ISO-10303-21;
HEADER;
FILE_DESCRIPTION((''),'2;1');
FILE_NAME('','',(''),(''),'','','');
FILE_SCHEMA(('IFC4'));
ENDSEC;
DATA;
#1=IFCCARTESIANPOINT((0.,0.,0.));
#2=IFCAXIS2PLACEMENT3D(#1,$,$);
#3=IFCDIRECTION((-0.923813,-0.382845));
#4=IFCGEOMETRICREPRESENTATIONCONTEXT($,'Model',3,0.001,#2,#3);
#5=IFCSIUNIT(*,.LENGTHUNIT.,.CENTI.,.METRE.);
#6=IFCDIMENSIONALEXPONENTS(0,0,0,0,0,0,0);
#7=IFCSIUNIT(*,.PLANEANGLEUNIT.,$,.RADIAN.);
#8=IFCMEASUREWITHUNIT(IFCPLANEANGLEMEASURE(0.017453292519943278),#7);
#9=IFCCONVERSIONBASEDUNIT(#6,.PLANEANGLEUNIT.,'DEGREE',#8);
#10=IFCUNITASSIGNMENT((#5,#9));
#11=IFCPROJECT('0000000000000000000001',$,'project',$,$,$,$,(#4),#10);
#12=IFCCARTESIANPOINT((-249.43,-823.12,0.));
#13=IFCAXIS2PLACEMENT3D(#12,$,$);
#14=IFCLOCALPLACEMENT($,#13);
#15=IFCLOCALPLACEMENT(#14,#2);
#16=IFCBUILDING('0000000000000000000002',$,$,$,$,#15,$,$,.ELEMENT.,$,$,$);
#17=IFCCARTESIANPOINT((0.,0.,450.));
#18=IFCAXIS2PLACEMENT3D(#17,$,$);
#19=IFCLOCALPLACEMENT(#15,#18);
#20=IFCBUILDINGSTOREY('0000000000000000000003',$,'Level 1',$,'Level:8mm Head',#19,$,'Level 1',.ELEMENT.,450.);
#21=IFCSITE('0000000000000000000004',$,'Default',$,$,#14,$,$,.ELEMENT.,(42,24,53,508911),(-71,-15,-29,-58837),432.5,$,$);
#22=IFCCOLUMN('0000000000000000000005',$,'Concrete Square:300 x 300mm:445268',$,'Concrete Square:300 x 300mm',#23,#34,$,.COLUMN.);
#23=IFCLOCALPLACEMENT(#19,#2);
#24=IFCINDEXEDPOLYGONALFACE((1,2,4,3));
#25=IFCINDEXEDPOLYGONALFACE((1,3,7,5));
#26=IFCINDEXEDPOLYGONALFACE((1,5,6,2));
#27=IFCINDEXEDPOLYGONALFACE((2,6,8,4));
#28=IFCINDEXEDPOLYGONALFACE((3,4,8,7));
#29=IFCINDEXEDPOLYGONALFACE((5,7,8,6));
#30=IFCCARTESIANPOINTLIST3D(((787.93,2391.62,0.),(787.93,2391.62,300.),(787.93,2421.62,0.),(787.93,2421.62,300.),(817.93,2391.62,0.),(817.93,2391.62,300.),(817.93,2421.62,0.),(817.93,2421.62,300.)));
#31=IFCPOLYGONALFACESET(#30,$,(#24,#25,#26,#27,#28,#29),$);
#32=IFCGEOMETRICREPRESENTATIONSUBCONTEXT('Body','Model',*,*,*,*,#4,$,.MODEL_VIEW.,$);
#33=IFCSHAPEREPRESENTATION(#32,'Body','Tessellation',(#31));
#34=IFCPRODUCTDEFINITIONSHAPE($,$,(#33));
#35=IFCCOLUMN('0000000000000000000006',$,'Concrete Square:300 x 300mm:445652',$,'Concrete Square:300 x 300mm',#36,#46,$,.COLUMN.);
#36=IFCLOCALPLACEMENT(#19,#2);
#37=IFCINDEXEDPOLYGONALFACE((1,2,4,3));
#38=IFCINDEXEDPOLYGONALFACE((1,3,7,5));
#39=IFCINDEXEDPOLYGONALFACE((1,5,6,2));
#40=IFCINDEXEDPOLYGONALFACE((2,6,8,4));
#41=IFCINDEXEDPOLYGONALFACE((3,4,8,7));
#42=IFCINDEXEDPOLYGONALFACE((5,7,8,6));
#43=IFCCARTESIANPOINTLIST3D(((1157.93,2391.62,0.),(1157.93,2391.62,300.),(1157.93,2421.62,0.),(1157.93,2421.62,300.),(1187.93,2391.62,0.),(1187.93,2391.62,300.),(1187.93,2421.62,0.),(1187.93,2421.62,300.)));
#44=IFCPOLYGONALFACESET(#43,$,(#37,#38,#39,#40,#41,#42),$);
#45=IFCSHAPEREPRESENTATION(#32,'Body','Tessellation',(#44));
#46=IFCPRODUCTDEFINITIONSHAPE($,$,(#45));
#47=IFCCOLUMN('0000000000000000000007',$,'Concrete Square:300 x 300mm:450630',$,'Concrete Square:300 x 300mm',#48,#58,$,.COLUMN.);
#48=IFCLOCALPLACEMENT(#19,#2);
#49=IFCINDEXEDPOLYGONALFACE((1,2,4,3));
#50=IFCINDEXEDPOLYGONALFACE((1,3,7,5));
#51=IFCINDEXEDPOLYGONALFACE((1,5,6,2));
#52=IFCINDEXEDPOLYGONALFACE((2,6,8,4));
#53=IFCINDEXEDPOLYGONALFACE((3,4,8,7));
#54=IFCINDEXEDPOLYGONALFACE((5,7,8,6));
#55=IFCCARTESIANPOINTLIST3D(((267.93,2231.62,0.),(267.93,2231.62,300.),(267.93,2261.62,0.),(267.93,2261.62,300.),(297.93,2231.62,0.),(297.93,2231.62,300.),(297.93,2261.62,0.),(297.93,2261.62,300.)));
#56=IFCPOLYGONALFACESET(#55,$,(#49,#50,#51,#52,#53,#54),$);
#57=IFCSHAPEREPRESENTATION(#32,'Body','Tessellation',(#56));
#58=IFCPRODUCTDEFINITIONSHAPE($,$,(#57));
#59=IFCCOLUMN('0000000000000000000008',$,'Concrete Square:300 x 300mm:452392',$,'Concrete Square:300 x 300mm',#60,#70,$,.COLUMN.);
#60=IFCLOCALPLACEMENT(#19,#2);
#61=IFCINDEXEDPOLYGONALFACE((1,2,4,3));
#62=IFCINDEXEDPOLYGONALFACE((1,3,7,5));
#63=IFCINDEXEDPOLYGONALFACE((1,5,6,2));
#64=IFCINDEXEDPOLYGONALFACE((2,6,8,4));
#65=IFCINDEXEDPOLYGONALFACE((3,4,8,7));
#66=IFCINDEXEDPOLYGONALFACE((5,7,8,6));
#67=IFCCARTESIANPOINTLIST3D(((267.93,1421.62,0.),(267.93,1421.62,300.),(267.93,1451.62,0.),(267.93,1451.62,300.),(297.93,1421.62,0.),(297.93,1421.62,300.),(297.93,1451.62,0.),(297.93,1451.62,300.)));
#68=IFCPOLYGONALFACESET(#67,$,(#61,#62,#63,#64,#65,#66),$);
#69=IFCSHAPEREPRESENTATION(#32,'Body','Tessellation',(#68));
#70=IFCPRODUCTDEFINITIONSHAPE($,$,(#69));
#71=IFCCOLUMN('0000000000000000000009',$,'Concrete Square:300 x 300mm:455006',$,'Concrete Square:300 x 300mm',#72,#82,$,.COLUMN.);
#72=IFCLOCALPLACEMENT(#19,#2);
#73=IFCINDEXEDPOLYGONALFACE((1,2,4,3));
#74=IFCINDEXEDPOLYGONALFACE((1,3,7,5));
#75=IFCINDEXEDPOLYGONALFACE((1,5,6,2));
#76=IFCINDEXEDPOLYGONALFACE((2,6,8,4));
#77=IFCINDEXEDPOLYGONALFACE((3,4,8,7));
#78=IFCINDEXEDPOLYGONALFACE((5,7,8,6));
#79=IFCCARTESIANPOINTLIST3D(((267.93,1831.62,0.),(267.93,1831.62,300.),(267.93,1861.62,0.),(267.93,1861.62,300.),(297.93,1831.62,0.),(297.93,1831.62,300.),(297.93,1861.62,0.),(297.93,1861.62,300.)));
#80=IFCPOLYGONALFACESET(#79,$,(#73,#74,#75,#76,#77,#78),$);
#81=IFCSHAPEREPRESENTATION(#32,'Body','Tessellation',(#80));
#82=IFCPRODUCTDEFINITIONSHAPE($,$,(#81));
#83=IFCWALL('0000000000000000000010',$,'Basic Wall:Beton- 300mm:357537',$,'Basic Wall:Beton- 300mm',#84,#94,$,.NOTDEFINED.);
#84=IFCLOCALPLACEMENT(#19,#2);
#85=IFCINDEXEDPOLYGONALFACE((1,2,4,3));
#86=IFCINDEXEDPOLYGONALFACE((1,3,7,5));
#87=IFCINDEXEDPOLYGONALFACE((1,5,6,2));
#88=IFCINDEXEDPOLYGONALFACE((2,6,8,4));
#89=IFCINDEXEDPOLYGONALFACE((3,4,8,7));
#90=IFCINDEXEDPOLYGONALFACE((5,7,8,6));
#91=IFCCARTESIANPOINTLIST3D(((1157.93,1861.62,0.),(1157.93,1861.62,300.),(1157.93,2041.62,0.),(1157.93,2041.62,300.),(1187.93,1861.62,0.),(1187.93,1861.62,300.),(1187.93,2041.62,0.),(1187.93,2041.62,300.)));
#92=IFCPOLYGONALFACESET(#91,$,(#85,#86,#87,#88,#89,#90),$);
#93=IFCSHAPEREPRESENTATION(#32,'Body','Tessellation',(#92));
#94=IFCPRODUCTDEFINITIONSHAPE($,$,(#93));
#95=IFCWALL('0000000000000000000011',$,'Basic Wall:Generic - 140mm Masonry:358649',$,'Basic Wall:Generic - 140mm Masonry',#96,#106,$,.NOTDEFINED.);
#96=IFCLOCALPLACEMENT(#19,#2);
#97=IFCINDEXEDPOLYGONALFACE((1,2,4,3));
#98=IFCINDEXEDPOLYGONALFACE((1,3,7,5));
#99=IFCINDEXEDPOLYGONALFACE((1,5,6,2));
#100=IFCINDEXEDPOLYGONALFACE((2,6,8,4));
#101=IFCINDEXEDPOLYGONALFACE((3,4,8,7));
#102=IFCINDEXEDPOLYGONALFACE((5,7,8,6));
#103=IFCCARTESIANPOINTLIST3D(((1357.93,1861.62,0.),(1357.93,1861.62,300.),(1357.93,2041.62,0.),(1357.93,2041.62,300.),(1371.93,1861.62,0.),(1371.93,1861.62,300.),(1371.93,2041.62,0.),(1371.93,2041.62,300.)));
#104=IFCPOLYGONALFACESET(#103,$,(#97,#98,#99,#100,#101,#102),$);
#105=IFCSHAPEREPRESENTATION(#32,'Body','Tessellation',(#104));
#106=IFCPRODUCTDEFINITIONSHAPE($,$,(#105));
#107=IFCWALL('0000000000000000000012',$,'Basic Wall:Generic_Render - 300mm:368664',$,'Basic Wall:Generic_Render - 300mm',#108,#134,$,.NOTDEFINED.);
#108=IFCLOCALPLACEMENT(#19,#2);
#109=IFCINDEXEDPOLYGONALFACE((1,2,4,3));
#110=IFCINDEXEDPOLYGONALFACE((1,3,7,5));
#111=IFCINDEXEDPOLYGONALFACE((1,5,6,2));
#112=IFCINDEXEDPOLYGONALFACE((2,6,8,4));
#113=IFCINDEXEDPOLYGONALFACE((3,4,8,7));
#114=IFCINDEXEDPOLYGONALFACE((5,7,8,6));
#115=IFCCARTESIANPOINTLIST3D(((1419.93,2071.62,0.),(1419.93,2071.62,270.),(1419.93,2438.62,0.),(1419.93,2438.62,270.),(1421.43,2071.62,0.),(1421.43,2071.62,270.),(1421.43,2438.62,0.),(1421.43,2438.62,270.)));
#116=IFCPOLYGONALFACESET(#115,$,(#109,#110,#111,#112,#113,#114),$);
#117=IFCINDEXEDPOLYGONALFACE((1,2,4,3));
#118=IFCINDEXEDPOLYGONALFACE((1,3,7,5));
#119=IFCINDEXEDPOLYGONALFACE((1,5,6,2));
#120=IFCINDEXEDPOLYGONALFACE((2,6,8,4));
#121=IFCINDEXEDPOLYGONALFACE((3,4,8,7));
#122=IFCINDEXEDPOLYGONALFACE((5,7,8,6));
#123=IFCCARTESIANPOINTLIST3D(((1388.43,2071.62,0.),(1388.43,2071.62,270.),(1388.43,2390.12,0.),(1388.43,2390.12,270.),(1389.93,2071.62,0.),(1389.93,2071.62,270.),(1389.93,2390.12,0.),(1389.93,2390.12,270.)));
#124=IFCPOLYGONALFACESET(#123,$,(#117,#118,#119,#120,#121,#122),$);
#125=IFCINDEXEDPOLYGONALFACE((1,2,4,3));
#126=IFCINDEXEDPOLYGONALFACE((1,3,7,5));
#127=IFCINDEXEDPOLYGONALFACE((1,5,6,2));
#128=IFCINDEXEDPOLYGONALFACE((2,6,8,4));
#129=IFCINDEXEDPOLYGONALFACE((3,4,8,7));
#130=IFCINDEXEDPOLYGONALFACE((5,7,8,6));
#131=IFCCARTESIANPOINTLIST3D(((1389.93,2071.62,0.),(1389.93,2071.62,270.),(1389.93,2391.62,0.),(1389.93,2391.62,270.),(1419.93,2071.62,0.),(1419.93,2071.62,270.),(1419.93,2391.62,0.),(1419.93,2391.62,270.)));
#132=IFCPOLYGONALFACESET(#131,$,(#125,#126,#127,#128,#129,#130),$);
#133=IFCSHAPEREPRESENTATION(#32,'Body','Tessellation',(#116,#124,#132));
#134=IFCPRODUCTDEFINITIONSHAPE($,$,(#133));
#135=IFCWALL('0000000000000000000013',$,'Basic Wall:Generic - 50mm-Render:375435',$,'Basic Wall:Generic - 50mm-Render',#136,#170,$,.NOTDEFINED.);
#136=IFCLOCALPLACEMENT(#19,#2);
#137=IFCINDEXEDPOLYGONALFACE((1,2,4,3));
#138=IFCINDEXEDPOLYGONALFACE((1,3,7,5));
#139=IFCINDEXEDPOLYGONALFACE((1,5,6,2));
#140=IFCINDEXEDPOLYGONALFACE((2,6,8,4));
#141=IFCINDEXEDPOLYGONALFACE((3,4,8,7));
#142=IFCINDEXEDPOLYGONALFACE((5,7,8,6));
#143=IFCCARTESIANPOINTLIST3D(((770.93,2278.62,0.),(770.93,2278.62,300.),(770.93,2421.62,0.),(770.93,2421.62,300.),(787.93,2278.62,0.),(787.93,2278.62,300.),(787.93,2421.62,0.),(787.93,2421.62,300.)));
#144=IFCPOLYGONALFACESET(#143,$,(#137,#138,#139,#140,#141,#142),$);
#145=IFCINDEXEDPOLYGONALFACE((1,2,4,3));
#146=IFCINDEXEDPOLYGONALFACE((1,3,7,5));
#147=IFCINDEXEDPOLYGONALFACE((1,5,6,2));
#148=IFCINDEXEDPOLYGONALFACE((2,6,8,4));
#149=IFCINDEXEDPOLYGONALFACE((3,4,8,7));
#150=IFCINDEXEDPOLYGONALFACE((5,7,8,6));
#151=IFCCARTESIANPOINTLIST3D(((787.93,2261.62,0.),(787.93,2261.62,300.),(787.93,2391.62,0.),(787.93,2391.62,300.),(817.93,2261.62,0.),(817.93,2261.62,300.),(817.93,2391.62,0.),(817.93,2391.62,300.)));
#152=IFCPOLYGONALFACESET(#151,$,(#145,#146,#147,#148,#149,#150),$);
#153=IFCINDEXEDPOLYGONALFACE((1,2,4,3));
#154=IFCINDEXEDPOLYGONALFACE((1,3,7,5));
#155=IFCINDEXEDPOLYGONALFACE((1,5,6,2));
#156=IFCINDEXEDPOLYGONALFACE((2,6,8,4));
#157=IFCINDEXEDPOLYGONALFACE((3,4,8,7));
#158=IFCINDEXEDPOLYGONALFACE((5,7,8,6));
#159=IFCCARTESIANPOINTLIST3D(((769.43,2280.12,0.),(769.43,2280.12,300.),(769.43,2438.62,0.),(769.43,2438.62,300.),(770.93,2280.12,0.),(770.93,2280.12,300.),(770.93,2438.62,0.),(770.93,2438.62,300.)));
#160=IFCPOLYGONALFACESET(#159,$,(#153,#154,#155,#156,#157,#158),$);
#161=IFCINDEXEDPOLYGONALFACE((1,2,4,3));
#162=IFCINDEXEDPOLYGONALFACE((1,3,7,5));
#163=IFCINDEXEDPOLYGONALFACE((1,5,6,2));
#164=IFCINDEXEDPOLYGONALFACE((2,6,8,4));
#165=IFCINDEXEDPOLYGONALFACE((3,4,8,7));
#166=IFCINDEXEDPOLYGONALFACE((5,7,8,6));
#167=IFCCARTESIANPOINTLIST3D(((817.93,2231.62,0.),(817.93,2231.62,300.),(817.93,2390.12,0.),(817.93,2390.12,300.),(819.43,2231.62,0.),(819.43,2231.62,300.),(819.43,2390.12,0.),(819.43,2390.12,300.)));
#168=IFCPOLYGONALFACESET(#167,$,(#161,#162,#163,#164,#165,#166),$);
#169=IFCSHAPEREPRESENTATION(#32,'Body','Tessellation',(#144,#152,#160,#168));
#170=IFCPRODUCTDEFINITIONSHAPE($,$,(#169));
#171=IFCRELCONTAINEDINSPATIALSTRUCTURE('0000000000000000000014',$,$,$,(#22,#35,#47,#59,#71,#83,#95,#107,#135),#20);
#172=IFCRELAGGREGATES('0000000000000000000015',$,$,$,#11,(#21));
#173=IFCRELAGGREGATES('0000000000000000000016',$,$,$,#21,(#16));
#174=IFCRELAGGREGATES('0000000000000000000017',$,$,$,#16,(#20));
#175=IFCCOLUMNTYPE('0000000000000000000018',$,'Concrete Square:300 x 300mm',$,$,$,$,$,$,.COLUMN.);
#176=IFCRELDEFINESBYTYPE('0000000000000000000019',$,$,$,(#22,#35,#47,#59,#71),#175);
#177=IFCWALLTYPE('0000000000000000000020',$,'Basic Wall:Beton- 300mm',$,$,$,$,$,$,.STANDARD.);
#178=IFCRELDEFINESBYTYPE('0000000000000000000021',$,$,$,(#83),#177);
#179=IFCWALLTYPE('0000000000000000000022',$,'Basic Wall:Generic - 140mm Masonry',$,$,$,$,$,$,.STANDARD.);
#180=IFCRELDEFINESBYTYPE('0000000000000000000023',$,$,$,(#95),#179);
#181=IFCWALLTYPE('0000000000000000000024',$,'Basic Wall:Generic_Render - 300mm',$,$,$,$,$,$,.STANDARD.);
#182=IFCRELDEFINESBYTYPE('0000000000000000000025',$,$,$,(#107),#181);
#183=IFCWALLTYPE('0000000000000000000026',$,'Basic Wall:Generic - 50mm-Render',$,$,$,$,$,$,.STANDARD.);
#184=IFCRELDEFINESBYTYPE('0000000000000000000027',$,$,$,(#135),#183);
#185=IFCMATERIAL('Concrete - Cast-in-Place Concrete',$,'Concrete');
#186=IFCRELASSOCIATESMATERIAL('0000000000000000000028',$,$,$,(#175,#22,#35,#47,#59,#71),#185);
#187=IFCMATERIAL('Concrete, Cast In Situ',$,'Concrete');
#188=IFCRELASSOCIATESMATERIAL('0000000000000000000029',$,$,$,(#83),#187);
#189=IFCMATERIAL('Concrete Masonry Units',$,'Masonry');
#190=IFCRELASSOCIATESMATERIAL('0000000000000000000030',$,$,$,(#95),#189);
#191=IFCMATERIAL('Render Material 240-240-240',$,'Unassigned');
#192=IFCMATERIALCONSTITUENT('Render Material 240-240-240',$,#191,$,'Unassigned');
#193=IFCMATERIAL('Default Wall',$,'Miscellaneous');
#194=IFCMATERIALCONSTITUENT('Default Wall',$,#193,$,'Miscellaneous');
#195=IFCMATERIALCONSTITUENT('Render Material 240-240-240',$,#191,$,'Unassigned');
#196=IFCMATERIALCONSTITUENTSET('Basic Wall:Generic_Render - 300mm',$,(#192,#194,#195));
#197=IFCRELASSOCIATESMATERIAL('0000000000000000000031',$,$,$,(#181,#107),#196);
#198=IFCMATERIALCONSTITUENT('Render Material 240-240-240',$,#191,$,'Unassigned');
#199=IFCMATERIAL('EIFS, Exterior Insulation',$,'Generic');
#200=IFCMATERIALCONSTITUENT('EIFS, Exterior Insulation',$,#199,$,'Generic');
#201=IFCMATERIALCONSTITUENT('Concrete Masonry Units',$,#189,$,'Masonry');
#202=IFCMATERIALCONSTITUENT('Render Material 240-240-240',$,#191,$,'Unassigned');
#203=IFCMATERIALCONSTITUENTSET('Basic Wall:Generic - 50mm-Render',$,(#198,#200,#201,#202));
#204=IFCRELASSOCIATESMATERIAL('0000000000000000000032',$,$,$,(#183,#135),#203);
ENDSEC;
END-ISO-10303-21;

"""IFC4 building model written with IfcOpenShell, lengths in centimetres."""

from ifc_helpers import new_model, entity, si_unit, converted_unit, direction, frame, origin, place, context, subcontext, project, spatial, indexed_curve, outline, extrude, source, transform, mapped, material, constituent, constituent_set, type_object, type_shapes, element, save


model = new_model("IFC4")

# Units and contexts
model_context = context("Model", 3, precision=0.001, world=origin(), true_north=direction((-0.923813, -0.382845)))
body_context = subcontext(model_context, "Body", "Model", "MODEL_VIEW")
ifc_project = project(units=[si_unit("LENGTHUNIT", "METRE", prefix="CENTI"), converted_unit("PLANEANGLEUNIT", "DEGREE", entity("IfcPlaneAngleMeasure", 0.017453292519943278), si_unit("PLANEANGLEUNIT", "RADIAN"), dimensions=[0, 0, 0, 0, 0, 0, 0])], contexts=[model_context])

# Site, building, storey
site_placement = place(None, frame((-249.43, -823.12, 0.0)))
site = spatial("IfcSite", under=ifc_project, at=site_placement, Name="Default", CompositionType="ELEMENT", RefLatitude=(42, 24, 53, 508911), RefLongitude=(-71, -15, -29, -58837), RefElevation=432.5)
building_placement = place(site_placement, origin())
building = spatial("IfcBuilding", under=site, at=building_placement, CompositionType="ELEMENT")
storey_placement = place(building_placement, frame((0.0, 0.0, 450.0)))
storey = spatial("IfcBuildingStorey", under=building, at=storey_placement, Name="Level 1", ObjectType="Level:8mm Head", LongName="Level 1", CompositionType="ELEMENT", Elevation=450.0)

# Columns
ifc_material_1 = material(Name="Concrete - Cast-in-Place Concrete", Category="Concrete")
column_type = type_object("IfcColumnType", Name="Concrete Square:300 x 300mm", PredefinedType="COLUMN", material=ifc_material_1)
shared_shape_1 = source(origin(), body_context, "Body", "SweptSolid", [
    extrude(outline(indexed_curve([(-15.0, -15.0), (15.0, -15.0), (15.0, 15.0), (-15.0, 15.0), (-15.0, -15.0)], self_intersect=False)), frame((0.0, 0.0, 450.0), z_axis=(0.0, 0.0, 1.0), x_axis=(-1.0, 0.0, 0.0)), (0.0, 0.0, 1.0), 300.0),
])
type_shapes(column_type, [shared_shape_1])
for number, where, name in (
    (1, (802.93, 2406.62, -450.0), "Concrete Square:300 x 300mm:445268"),
    (2, (1172.93, 2406.62, -450.0), "Concrete Square:300 x 300mm:445652"),
    (3, (282.93, 2246.62, -450.0), "Concrete Square:300 x 300mm:450630"),
    (4, (282.93, 1436.62, -450.0), "Concrete Square:300 x 300mm:452392"),
    (5, (282.93, 1846.62, -450.0), "Concrete Square:300 x 300mm:455006"),
):
    element("IfcColumn", number, at=place(storey_placement, frame(where)), inside=storey, type_object=column_type, material=ifc_material_1, Name=name, ObjectType="Concrete Square:300 x 300mm", PredefinedType="COLUMN", context=body_context, shape_type="MappedRepresentation", body=[
        mapped(shared_shape_1, transform((0.0, 0.0, 0.0), scale=1.0)),
    ])

# Walls
ifc_material_2 = material(Name="Concrete, Cast In Situ", Category="Concrete")
wall_type_1 = type_object("IfcWallType", Name="Basic Wall:Beton- 300mm", PredefinedType="STANDARD")
wall_1_placement = place(storey_placement, frame((1172.93, 2041.62, 0.0), z_axis=(0.0, 0.0, 1.0), x_axis=(0.0, -1.0, 0.0)))
element("IfcWall", 6, at=wall_1_placement, inside=storey, type_object=wall_type_1, material=ifc_material_2, Name="Basic Wall:Beton- 300mm:357537", ObjectType="Basic Wall:Beton- 300mm", PredefinedType="NOTDEFINED", context=body_context, shape_type="SweptSolid", body=[
    extrude(outline(indexed_curve([(180.0, 15.0), (0.0, 15.0), (0.0, -15.0), (180.0, -15.0), (180.0, 15.0)], self_intersect=False)), origin(), (0.0, 0.0, 1.0), 300.0),
])
ifc_material_3 = material(Name="Concrete Masonry Units", Category="Masonry")
wall_type_2 = type_object("IfcWallType", Name="Basic Wall:Generic - 140mm Masonry", PredefinedType="STANDARD")
wall_2_placement = place(storey_placement, frame((1364.93, 2041.62, 0.0), z_axis=(0.0, 0.0, 1.0), x_axis=(0.0, -1.0, 0.0)))
element("IfcWall", 7, at=wall_2_placement, inside=storey, type_object=wall_type_2, material=ifc_material_3, Name="Basic Wall:Generic - 140mm Masonry:358649", ObjectType="Basic Wall:Generic - 140mm Masonry", PredefinedType="NOTDEFINED", context=body_context, shape_type="SweptSolid", body=[
    extrude(outline(indexed_curve([(180.0, 7.0), (0.0, 7.0), (0.0, -7.0), (180.0, -7.0), (180.0, 7.0)], self_intersect=False)), origin(), (0.0, 0.0, 1.0), 300.0),
])
ifc_material_4 = material(Name="Render Material 240-240-240", Category="Unassigned")
ifc_constituent_1 = constituent(ifc_material_4, Name="Render Material 240-240-240", Category="Unassigned")
ifc_material_5 = material(Name="Default Wall", Category="Miscellaneous")
ifc_constituent_2 = constituent(ifc_material_5, Name="Default Wall", Category="Miscellaneous")
ifc_constituent_3 = constituent(ifc_material_4, Name="Render Material 240-240-240", Category="Unassigned")
ifc_constituent_set_1 = constituent_set(constituents=[ifc_constituent_1, ifc_constituent_2, ifc_constituent_3], Name="Basic Wall:Generic_Render - 300mm")
wall_type_3 = type_object("IfcWallType", Name="Basic Wall:Generic_Render - 300mm", PredefinedType="STANDARD", material=ifc_constituent_set_1)
wall_3_placement = place(storey_placement, frame((1404.93, 2071.62, 0.0), z_axis=(0.0, 0.0, 1.0), x_axis=(0.0, 1.0, 0.0)))
element("IfcWall", 8, at=wall_3_placement, inside=storey, type_object=wall_type_3, material=ifc_constituent_set_1, Name="Basic Wall:Generic_Render - 300mm:368664", ObjectType="Basic Wall:Generic_Render - 300mm", PredefinedType="NOTDEFINED", context=body_context, shape_type="SweptSolid", body=[
    extrude(outline(indexed_curve([(-0.75, -183.5), (0.75, -183.5), (0.75, 183.5), (-0.75, 183.5), (-0.75, -183.5)], self_intersect=False)), frame((183.5, -15.75, 0.0), z_axis=(0.0, 0.0, 1.0), x_axis=(0.0, 1.0, 0.0)), (0.0, 0.0, 1.0), 270.0),
    extrude(outline(indexed_curve([(-0.75, -159.25), (0.75, -159.25), (0.75, 159.25), (-0.75, 159.25), (-0.75, -159.25)], self_intersect=False)), frame((159.25, 15.75, 0.0), z_axis=(0.0, 0.0, 1.0), x_axis=(0.0, -1.0, 0.0)), (0.0, 0.0, 1.0), 270.0),
    extrude(outline(indexed_curve([(-160.0, -15.0), (160.0, -15.0), (160.0, 15.0), (-160.0, 15.0), (-160.0, -15.0)], self_intersect=False)), frame((160.0, 0.0, 0.0)), (0.0, 0.0, 1.0), 270.0),
])
ifc_constituent_4 = constituent(ifc_material_4, Name="Render Material 240-240-240", Category="Unassigned")
ifc_material_6 = material(Name="EIFS, Exterior Insulation", Category="Generic")
ifc_constituent_5 = constituent(ifc_material_6, Name="EIFS, Exterior Insulation", Category="Generic")
ifc_constituent_6 = constituent(ifc_material_3, Name="Concrete Masonry Units", Category="Masonry")
ifc_constituent_7 = constituent(ifc_material_4, Name="Render Material 240-240-240", Category="Unassigned")
ifc_constituent_set_2 = constituent_set(constituents=[ifc_constituent_4, ifc_constituent_5, ifc_constituent_6, ifc_constituent_7], Name="Basic Wall:Generic - 50mm-Render")
wall_type_4 = type_object("IfcWallType", Name="Basic Wall:Generic - 50mm-Render", PredefinedType="STANDARD", material=ifc_constituent_set_2)
wall_4_placement = place(storey_placement, frame((794.43, 2280.12, 0.0), z_axis=(0.0, 0.0, 1.0), x_axis=(0.0, 1.0, 0.0)))
element("IfcWall", 9, at=wall_4_placement, inside=storey, type_object=wall_type_4, material=ifc_constituent_set_2, Name="Basic Wall:Generic - 50mm-Render:375435", ObjectType="Basic Wall:Generic - 50mm-Render", PredefinedType="NOTDEFINED", context=body_context, shape_type="SweptSolid", body=[
    extrude(outline(indexed_curve([(-8.5, -71.5), (8.5, -71.5), (8.5, 71.5), (-8.5, 71.5), (-8.5, -71.5)], self_intersect=False)), frame((70.0, 15.0, 0.0), z_axis=(0.0, 0.0, 1.0), x_axis=(0.0, -1.0, 0.0)), (0.0, 0.0, 1.0), 300.0),
    extrude(outline(indexed_curve([(-15.0, -65.0), (15.0, -65.0), (15.0, 65.0), (-15.0, 65.0), (-15.0, -65.0)], self_intersect=False)), frame((46.5, -8.5, 0.0), z_axis=(0.0, 0.0, 1.0), x_axis=(0.0, 1.0, 0.0)), (0.0, 0.0, 1.0), 300.0),
    extrude(outline(indexed_curve([(-0.75, -79.25), (0.75, -79.25), (0.75, 79.25), (-0.75, 79.25), (-0.75, -79.25)], self_intersect=False)), frame((79.25, 24.25, 0.0), z_axis=(0.0, 0.0, 1.0), x_axis=(0.0, -1.0, 0.0)), (0.0, 0.0, 1.0), 300.0),
    extrude(outline(indexed_curve([(-0.75, -79.25), (0.75, -79.25), (0.75, 79.25), (-0.75, 79.25), (-0.75, -79.25)], self_intersect=False)), frame((30.75, -24.25, 0.0), z_axis=(0.0, 0.0, 1.0), x_axis=(0.0, -1.0, 0.0)), (0.0, 0.0, 1.0), 300.0),
])

save(model, "model.ifc")
